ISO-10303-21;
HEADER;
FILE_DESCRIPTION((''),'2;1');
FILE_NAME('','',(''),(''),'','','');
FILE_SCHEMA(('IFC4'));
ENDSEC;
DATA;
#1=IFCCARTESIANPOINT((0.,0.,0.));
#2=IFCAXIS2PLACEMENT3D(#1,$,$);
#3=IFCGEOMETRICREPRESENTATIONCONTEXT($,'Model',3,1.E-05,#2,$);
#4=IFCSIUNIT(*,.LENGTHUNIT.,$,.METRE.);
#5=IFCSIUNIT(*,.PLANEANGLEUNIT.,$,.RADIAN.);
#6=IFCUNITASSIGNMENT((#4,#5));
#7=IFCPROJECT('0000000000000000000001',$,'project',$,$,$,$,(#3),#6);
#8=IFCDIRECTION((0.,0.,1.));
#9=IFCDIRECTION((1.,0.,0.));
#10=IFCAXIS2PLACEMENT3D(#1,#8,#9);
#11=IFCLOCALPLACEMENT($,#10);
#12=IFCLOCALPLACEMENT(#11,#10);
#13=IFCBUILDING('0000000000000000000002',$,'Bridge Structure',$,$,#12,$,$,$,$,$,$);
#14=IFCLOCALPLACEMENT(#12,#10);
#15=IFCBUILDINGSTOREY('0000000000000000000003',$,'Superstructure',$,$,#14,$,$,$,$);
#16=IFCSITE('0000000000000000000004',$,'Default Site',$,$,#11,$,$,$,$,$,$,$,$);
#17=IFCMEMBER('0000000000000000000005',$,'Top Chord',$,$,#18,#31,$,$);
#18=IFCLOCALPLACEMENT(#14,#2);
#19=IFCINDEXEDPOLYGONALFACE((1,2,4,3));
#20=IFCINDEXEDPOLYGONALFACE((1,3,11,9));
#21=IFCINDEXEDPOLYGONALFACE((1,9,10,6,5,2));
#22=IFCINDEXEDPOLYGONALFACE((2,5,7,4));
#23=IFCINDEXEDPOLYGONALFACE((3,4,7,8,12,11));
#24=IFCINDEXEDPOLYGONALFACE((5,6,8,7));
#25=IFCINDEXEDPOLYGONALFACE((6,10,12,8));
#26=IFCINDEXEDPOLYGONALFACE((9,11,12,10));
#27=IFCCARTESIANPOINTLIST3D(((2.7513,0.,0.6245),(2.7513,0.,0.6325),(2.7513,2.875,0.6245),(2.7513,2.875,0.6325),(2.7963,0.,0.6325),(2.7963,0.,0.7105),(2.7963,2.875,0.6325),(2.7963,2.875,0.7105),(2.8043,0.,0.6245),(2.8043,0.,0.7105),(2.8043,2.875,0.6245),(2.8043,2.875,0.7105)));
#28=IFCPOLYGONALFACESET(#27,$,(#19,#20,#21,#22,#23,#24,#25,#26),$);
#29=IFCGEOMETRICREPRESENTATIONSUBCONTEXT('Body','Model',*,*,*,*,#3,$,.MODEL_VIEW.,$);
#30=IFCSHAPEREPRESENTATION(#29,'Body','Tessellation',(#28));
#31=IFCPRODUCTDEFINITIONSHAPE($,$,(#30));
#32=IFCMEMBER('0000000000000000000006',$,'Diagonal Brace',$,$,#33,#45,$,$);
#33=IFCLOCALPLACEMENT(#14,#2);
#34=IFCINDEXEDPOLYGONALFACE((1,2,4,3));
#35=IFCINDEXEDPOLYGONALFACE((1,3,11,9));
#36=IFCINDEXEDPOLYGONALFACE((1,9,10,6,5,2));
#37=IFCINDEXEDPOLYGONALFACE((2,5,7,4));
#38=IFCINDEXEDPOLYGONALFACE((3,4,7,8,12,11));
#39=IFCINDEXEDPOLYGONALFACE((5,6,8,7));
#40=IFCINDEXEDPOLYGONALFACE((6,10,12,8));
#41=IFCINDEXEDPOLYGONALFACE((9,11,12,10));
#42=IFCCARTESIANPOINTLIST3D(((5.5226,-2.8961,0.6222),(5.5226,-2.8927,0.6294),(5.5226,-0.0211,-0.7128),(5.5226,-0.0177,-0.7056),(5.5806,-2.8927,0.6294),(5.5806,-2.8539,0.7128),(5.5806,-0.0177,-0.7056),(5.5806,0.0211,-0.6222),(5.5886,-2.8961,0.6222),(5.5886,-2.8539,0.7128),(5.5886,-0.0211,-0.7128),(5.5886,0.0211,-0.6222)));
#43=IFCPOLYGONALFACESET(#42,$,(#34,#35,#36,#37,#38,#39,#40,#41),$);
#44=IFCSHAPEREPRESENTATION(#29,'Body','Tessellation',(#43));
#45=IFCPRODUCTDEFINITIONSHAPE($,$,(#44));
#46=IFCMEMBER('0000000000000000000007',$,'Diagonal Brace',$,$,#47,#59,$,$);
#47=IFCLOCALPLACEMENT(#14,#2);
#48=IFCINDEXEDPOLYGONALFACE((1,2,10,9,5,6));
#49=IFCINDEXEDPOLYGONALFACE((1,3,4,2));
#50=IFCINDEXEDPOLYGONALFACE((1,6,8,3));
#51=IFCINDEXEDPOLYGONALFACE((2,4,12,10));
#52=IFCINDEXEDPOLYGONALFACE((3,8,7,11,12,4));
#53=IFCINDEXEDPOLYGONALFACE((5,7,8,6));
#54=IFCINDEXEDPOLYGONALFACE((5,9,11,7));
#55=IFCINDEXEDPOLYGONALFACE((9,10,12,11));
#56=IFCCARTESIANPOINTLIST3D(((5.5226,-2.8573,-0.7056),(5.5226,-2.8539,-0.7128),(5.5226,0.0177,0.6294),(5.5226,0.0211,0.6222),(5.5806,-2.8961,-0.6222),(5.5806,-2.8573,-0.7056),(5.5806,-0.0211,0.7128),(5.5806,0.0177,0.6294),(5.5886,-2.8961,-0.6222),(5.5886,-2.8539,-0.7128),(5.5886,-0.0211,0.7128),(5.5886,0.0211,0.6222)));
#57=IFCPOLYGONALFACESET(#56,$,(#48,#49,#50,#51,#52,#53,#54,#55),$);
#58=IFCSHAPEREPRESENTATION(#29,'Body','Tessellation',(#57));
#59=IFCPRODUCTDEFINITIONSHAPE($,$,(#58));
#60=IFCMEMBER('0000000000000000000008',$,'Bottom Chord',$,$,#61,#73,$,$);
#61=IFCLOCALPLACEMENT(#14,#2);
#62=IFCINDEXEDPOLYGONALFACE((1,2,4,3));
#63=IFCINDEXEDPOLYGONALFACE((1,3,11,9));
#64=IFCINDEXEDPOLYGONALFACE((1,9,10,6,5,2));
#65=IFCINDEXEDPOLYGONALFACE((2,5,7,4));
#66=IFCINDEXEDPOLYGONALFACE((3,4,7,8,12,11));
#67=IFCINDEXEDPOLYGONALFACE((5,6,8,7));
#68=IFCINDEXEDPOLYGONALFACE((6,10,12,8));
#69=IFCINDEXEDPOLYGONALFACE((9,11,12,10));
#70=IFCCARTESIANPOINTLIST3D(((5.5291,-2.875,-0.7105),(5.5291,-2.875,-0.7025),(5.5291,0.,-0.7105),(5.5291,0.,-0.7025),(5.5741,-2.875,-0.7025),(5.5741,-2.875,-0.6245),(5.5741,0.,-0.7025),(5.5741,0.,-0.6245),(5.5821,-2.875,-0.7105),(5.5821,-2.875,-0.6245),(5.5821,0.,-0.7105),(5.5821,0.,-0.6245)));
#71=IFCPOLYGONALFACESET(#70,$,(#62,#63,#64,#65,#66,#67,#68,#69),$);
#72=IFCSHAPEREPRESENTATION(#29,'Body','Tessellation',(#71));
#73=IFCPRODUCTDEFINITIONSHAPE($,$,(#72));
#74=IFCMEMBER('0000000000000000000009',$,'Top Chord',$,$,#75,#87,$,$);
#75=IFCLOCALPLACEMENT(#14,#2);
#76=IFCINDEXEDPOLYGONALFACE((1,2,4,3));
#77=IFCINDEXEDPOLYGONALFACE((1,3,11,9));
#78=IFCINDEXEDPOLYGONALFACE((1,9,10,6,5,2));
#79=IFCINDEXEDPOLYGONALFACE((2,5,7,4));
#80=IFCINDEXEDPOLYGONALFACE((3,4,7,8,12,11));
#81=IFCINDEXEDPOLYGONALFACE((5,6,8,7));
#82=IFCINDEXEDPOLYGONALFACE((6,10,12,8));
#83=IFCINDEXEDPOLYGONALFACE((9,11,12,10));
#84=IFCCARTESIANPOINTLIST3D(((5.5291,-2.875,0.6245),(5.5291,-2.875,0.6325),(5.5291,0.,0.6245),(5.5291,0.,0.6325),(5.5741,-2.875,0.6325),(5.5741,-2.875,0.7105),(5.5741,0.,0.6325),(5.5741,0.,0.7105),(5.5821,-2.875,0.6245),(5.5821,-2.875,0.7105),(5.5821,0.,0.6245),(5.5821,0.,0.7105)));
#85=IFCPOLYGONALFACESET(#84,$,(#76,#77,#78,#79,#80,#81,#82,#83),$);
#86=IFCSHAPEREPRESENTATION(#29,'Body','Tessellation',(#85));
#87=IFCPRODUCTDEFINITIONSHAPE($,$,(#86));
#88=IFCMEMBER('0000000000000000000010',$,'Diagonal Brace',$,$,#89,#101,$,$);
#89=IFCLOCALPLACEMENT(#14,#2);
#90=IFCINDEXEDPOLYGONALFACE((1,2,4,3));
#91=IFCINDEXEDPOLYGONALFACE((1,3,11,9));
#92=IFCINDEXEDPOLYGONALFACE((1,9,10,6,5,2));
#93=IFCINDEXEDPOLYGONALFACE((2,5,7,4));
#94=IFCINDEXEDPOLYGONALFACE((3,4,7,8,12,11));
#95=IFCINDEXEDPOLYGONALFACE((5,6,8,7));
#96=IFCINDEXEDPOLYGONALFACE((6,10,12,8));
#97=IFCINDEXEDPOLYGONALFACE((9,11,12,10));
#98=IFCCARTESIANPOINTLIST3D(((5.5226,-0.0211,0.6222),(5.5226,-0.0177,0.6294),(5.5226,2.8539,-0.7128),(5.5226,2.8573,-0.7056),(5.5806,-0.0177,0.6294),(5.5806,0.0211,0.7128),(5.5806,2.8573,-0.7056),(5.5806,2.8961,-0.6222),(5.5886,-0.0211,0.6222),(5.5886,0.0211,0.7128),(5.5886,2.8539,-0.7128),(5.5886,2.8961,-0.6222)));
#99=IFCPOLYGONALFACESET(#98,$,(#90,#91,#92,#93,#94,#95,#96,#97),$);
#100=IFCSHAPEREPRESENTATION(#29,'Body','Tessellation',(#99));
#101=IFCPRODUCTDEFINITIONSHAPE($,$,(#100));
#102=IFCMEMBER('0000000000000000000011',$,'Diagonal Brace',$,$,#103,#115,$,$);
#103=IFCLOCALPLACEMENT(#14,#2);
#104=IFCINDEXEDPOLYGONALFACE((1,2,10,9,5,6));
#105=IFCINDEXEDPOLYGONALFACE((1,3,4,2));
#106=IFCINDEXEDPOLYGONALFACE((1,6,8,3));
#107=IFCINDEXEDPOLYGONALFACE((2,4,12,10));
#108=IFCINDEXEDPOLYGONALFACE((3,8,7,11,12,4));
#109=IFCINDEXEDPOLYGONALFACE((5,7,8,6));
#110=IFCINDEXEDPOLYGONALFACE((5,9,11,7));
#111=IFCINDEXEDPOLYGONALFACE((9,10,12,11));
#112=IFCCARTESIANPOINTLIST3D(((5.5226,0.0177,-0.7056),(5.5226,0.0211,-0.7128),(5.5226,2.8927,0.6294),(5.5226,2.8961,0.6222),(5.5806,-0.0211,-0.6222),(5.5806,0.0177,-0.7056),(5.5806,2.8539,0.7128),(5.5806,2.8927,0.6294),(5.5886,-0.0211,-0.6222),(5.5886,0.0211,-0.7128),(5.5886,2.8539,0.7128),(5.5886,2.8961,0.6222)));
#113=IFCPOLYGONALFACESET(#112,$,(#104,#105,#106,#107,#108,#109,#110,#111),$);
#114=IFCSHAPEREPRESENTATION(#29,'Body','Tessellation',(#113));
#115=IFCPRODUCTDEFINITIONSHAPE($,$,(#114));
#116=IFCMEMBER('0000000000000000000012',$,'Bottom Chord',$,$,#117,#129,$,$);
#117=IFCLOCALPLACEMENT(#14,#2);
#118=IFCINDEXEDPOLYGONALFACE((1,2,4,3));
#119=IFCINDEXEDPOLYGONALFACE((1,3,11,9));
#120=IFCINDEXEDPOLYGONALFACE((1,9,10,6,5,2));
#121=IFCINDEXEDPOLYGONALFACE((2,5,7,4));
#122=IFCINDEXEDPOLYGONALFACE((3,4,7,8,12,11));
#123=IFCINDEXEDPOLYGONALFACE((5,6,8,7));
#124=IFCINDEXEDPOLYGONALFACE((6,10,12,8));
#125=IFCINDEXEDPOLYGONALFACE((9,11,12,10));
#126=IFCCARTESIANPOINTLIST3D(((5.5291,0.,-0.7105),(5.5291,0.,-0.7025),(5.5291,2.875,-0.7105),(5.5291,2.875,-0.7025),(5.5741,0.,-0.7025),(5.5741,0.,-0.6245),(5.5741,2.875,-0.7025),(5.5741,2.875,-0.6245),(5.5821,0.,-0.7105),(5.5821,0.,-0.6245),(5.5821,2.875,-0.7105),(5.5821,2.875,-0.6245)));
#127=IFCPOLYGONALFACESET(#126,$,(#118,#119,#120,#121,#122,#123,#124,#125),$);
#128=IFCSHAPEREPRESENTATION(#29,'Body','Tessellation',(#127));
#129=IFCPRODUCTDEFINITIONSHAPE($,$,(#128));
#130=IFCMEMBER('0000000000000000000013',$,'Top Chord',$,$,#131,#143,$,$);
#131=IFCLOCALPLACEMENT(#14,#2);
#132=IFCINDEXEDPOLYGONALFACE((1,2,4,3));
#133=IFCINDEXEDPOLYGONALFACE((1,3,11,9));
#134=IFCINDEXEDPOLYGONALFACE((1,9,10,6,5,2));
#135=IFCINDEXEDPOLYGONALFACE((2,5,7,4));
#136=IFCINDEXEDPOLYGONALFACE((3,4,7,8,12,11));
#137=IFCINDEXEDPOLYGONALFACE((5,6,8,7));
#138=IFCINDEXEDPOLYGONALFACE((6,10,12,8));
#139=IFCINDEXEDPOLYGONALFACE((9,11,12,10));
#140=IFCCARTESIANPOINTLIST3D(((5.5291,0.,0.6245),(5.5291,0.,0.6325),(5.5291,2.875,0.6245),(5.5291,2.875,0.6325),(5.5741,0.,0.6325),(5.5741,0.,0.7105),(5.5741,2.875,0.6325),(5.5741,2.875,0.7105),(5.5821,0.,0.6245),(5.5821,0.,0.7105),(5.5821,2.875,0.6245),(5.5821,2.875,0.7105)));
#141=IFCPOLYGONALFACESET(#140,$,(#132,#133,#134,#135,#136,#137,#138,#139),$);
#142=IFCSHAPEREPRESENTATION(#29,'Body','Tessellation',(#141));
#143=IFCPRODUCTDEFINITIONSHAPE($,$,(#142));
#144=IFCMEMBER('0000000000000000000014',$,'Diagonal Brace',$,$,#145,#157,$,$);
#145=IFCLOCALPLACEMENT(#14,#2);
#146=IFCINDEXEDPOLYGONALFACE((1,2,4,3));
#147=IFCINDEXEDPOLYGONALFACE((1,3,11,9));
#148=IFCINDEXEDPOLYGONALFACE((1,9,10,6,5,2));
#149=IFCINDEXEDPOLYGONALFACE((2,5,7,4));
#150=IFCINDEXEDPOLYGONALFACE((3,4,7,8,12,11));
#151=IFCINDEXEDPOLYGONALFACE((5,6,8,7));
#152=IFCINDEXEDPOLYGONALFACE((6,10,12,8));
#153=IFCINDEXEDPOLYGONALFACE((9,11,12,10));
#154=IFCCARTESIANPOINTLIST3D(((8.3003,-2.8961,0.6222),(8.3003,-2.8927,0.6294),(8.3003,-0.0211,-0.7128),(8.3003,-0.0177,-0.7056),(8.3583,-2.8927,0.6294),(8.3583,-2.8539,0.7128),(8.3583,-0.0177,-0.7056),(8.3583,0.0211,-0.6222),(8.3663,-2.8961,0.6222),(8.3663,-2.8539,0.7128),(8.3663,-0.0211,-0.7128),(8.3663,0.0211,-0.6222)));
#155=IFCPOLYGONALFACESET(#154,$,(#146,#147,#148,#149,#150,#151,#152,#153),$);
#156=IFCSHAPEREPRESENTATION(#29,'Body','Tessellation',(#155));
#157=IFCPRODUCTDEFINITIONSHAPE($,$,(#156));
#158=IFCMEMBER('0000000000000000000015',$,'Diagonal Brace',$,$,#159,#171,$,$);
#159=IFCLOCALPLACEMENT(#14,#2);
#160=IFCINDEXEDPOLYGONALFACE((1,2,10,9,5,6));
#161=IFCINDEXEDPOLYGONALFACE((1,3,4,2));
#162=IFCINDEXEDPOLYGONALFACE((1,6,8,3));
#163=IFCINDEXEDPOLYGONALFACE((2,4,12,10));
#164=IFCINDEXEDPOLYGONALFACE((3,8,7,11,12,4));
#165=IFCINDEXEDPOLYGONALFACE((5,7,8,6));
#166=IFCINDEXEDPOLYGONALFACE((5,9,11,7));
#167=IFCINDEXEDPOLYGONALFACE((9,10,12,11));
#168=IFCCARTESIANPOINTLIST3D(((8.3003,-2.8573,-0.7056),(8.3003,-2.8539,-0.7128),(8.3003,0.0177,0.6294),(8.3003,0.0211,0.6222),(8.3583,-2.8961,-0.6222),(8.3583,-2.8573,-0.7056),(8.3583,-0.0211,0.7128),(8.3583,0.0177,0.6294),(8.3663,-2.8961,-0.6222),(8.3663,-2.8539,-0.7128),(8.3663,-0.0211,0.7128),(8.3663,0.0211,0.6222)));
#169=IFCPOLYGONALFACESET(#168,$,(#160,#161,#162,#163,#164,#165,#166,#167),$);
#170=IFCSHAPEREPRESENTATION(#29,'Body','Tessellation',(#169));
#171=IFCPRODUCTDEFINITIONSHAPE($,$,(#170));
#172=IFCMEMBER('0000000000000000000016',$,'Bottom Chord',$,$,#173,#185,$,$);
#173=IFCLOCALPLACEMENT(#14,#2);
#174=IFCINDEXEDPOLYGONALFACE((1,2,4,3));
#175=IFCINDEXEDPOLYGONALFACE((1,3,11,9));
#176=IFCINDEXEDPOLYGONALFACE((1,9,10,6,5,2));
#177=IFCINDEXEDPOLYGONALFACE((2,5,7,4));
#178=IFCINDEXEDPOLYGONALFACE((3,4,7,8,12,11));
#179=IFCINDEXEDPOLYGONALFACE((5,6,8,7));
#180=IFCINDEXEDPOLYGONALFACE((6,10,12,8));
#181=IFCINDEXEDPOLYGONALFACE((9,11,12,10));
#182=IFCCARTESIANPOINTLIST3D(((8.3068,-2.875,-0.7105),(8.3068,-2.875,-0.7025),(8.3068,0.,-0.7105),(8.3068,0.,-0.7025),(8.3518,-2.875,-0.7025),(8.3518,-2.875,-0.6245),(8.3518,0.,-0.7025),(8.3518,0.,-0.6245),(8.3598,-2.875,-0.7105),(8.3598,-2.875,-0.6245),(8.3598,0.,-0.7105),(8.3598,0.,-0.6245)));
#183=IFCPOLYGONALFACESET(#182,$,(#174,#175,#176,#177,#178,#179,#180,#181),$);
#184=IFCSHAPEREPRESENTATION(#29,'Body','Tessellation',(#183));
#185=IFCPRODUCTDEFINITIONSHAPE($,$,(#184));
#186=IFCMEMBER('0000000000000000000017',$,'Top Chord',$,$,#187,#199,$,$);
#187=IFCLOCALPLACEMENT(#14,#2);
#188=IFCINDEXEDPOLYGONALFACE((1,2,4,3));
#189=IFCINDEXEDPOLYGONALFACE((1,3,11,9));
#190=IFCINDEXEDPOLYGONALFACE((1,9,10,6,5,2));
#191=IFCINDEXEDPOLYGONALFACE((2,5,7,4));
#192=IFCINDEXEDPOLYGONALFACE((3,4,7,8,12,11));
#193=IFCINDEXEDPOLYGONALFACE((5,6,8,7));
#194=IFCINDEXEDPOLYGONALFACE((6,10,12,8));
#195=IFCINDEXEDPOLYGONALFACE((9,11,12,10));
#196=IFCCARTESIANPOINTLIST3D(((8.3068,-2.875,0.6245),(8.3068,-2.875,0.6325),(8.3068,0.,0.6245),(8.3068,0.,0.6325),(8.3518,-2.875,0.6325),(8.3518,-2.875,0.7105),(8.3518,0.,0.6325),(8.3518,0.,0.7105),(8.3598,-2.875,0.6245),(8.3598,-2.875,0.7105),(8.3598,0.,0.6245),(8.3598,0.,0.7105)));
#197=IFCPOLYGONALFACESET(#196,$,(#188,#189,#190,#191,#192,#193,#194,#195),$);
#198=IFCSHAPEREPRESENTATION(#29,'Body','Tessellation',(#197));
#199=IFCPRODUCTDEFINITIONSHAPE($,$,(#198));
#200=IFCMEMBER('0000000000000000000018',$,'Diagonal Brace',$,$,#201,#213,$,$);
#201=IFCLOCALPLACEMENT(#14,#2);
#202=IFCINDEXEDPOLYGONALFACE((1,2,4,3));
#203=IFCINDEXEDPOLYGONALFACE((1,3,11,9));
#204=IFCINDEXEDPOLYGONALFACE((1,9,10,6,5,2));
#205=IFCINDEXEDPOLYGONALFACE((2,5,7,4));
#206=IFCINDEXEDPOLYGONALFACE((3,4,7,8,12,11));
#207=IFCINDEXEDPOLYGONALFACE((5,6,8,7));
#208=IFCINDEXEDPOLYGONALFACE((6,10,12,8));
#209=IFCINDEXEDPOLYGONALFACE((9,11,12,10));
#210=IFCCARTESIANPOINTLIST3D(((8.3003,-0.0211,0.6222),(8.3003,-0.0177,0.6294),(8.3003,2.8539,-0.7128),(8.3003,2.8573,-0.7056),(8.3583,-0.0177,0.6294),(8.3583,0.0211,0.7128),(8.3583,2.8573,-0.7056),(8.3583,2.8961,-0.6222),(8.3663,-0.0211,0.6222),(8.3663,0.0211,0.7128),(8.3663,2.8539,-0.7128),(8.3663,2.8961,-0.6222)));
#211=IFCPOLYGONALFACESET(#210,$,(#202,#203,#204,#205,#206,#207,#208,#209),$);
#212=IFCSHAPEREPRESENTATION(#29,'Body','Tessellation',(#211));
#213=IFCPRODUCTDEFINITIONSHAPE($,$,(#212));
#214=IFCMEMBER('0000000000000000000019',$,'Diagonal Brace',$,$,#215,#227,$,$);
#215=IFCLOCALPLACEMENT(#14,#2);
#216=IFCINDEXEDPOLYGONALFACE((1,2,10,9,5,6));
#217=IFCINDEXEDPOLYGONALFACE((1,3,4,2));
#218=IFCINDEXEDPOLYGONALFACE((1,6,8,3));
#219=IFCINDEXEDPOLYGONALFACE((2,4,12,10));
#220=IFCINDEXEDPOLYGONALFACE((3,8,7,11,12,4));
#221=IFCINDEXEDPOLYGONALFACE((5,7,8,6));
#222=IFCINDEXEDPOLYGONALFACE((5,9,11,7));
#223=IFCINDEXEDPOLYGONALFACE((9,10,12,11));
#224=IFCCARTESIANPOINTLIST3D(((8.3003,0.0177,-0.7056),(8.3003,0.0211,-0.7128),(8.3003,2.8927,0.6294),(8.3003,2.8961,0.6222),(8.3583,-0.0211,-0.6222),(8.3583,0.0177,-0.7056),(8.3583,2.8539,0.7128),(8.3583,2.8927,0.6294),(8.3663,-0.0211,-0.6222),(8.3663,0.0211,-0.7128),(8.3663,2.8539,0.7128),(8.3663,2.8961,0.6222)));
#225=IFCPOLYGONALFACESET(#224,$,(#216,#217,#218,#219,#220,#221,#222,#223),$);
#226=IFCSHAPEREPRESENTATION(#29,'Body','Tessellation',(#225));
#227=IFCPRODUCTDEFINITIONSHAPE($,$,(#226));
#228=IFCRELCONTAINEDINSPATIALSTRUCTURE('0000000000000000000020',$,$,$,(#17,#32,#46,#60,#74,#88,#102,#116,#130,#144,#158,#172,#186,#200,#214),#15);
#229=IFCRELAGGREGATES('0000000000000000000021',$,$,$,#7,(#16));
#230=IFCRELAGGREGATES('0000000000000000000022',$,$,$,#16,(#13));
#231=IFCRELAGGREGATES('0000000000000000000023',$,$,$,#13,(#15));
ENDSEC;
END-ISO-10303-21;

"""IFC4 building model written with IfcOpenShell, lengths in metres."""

from ifc_helpers import new_model, si_unit, frame, origin, origin_with_axes, origin_2d_with_axis, place, context, subcontext, project, spatial, l_section, extrude, element, save


model = new_model("IFC4")

# Units and contexts
model_context = context("Model", 3, precision=1e-05, world=origin())
body_context = subcontext(model_context, "Body", "Model", "MODEL_VIEW")
ifc_project = project(units=[si_unit("LENGTHUNIT", "METRE"), si_unit("PLANEANGLEUNIT", "RADIAN")], contexts=[model_context])

# Site, building, storey
site_placement = place(None, origin_with_axes())
site = spatial("IfcSite", under=ifc_project, at=site_placement, Name="Default Site")
building_placement = place(site_placement, origin_with_axes())
building = spatial("IfcBuilding", under=site, at=building_placement, Name="Bridge Structure")
storey_placement = place(building_placement, origin_with_axes())
storey = spatial("IfcBuildingStorey", under=building, at=storey_placement, Name="Superstructure")

# Members
member_1_placement = place(storey_placement, frame((2.7778, 0.0, 0.6675), z_axis=(0.0, 1.0, 0.0), x_axis=(-1.0, 0.0, 0.0)))
element("IfcMember", 1, at=member_1_placement, inside=storey, Name="Top Chord", context=body_context, shape_type="SweptSolid", body=[
    extrude(l_section(Depth=0.086, Width=0.053, Thickness=0.008, at=origin_2d_with_axis()), origin_with_axes(), (0.0, 0.0, 1.0), 2.875),
])
for number, where, z_axis, x_axis, name in (
    (2, (5.5556, -2.875, 0.6675), (0.0, 0.906987, -0.421158), (-1.0, 0.0, 0.0), "Diagonal Brace"),
    (3, (5.5556, -2.875, -0.6675), (0.0, 0.906987, 0.421158), (-1.0, 0.0, 0.0), "Diagonal Brace"),
):
    element("IfcMember", number, at=place(storey_placement, frame(where, z_axis=z_axis, x_axis=x_axis)), inside=storey, Name=name, context=body_context, shape_type="SweptSolid", body=[
        extrude(l_section(Depth=0.1, Width=0.066, Thickness=0.008, at=origin_2d_with_axis()), origin_with_axes(), (0.0, 0.0, 1.0), 3.1698),
    ])
for number, where, z_axis, x_axis, name in (
    (4, (5.5556, -2.875, -0.6675), (0.0, 1.0, 0.0), (-1.0, 0.0, 0.0), "Bottom Chord"),
    (5, (5.5556, -2.875, 0.6675), (0.0, 1.0, 0.0), (-1.0, 0.0, 0.0), "Top Chord"),
):
    element("IfcMember", number, at=place(storey_placement, frame(where, z_axis=z_axis, x_axis=x_axis)), inside=storey, Name=name, context=body_context, shape_type="SweptSolid", body=[
        extrude(l_section(Depth=0.086, Width=0.053, Thickness=0.008, at=origin_2d_with_axis()), origin_with_axes(), (0.0, 0.0, 1.0), 2.875),
    ])
for number, where, z_axis, x_axis, name in (
    (6, (5.5556, 0.0, 0.6675), (0.0, 0.906987, -0.421158), (-1.0, 0.0, 0.0), "Diagonal Brace"),
    (7, (5.5556, 0.0, -0.6675), (0.0, 0.906987, 0.421158), (-1.0, 0.0, 0.0), "Diagonal Brace"),
):
    element("IfcMember", number, at=place(storey_placement, frame(where, z_axis=z_axis, x_axis=x_axis)), inside=storey, Name=name, context=body_context, shape_type="SweptSolid", body=[
        extrude(l_section(Depth=0.1, Width=0.066, Thickness=0.008, at=origin_2d_with_axis()), origin_with_axes(), (0.0, 0.0, 1.0), 3.1698),
    ])
for number, where, z_axis, x_axis, name in (
    (8, (5.5556, 0.0, -0.6675), (0.0, 1.0, 0.0), (-1.0, 0.0, 0.0), "Bottom Chord"),
    (9, (5.5556, 0.0, 0.6675), (0.0, 1.0, 0.0), (-1.0, 0.0, 0.0), "Top Chord"),
):
    element("IfcMember", number, at=place(storey_placement, frame(where, z_axis=z_axis, x_axis=x_axis)), inside=storey, Name=name, context=body_context, shape_type="SweptSolid", body=[
        extrude(l_section(Depth=0.086, Width=0.053, Thickness=0.008, at=origin_2d_with_axis()), origin_with_axes(), (0.0, 0.0, 1.0), 2.875),
    ])
for number, where, z_axis, x_axis, name in (
    (10, (8.3333, -2.875, 0.6675), (0.0, 0.906987, -0.421158), (-1.0, 0.0, 0.0), "Diagonal Brace"),
    (11, (8.3333, -2.875, -0.6675), (0.0, 0.906987, 0.421158), (-1.0, 0.0, 0.0), "Diagonal Brace"),
):
    element("IfcMember", number, at=place(storey_placement, frame(where, z_axis=z_axis, x_axis=x_axis)), inside=storey, Name=name, context=body_context, shape_type="SweptSolid", body=[
        extrude(l_section(Depth=0.1, Width=0.066, Thickness=0.008, at=origin_2d_with_axis()), origin_with_axes(), (0.0, 0.0, 1.0), 3.1698),
    ])
for number, where, z_axis, x_axis, name in (
    (12, (8.3333, -2.875, -0.6675), (0.0, 1.0, 0.0), (-1.0, 0.0, 0.0), "Bottom Chord"),
    (13, (8.3333, -2.875, 0.6675), (0.0, 1.0, 0.0), (-1.0, 0.0, 0.0), "Top Chord"),
):
    element("IfcMember", number, at=place(storey_placement, frame(where, z_axis=z_axis, x_axis=x_axis)), inside=storey, Name=name, context=body_context, shape_type="SweptSolid", body=[
        extrude(l_section(Depth=0.086, Width=0.053, Thickness=0.008, at=origin_2d_with_axis()), origin_with_axes(), (0.0, 0.0, 1.0), 2.875),
    ])
for number, where, z_axis, x_axis, name in (
    (14, (8.3333, 0.0, 0.6675), (0.0, 0.906987, -0.421158), (-1.0, 0.0, 0.0), "Diagonal Brace"),
    (15, (8.3333, 0.0, -0.6675), (0.0, 0.906987, 0.421158), (-1.0, 0.0, 0.0), "Diagonal Brace"),
):
    element("IfcMember", number, at=place(storey_placement, frame(where, z_axis=z_axis, x_axis=x_axis)), inside=storey, Name=name, context=body_context, shape_type="SweptSolid", body=[
        extrude(l_section(Depth=0.1, Width=0.066, Thickness=0.008, at=origin_2d_with_axis()), origin_with_axes(), (0.0, 0.0, 1.0), 3.1698),
    ])

save(model, "model.ifc")
